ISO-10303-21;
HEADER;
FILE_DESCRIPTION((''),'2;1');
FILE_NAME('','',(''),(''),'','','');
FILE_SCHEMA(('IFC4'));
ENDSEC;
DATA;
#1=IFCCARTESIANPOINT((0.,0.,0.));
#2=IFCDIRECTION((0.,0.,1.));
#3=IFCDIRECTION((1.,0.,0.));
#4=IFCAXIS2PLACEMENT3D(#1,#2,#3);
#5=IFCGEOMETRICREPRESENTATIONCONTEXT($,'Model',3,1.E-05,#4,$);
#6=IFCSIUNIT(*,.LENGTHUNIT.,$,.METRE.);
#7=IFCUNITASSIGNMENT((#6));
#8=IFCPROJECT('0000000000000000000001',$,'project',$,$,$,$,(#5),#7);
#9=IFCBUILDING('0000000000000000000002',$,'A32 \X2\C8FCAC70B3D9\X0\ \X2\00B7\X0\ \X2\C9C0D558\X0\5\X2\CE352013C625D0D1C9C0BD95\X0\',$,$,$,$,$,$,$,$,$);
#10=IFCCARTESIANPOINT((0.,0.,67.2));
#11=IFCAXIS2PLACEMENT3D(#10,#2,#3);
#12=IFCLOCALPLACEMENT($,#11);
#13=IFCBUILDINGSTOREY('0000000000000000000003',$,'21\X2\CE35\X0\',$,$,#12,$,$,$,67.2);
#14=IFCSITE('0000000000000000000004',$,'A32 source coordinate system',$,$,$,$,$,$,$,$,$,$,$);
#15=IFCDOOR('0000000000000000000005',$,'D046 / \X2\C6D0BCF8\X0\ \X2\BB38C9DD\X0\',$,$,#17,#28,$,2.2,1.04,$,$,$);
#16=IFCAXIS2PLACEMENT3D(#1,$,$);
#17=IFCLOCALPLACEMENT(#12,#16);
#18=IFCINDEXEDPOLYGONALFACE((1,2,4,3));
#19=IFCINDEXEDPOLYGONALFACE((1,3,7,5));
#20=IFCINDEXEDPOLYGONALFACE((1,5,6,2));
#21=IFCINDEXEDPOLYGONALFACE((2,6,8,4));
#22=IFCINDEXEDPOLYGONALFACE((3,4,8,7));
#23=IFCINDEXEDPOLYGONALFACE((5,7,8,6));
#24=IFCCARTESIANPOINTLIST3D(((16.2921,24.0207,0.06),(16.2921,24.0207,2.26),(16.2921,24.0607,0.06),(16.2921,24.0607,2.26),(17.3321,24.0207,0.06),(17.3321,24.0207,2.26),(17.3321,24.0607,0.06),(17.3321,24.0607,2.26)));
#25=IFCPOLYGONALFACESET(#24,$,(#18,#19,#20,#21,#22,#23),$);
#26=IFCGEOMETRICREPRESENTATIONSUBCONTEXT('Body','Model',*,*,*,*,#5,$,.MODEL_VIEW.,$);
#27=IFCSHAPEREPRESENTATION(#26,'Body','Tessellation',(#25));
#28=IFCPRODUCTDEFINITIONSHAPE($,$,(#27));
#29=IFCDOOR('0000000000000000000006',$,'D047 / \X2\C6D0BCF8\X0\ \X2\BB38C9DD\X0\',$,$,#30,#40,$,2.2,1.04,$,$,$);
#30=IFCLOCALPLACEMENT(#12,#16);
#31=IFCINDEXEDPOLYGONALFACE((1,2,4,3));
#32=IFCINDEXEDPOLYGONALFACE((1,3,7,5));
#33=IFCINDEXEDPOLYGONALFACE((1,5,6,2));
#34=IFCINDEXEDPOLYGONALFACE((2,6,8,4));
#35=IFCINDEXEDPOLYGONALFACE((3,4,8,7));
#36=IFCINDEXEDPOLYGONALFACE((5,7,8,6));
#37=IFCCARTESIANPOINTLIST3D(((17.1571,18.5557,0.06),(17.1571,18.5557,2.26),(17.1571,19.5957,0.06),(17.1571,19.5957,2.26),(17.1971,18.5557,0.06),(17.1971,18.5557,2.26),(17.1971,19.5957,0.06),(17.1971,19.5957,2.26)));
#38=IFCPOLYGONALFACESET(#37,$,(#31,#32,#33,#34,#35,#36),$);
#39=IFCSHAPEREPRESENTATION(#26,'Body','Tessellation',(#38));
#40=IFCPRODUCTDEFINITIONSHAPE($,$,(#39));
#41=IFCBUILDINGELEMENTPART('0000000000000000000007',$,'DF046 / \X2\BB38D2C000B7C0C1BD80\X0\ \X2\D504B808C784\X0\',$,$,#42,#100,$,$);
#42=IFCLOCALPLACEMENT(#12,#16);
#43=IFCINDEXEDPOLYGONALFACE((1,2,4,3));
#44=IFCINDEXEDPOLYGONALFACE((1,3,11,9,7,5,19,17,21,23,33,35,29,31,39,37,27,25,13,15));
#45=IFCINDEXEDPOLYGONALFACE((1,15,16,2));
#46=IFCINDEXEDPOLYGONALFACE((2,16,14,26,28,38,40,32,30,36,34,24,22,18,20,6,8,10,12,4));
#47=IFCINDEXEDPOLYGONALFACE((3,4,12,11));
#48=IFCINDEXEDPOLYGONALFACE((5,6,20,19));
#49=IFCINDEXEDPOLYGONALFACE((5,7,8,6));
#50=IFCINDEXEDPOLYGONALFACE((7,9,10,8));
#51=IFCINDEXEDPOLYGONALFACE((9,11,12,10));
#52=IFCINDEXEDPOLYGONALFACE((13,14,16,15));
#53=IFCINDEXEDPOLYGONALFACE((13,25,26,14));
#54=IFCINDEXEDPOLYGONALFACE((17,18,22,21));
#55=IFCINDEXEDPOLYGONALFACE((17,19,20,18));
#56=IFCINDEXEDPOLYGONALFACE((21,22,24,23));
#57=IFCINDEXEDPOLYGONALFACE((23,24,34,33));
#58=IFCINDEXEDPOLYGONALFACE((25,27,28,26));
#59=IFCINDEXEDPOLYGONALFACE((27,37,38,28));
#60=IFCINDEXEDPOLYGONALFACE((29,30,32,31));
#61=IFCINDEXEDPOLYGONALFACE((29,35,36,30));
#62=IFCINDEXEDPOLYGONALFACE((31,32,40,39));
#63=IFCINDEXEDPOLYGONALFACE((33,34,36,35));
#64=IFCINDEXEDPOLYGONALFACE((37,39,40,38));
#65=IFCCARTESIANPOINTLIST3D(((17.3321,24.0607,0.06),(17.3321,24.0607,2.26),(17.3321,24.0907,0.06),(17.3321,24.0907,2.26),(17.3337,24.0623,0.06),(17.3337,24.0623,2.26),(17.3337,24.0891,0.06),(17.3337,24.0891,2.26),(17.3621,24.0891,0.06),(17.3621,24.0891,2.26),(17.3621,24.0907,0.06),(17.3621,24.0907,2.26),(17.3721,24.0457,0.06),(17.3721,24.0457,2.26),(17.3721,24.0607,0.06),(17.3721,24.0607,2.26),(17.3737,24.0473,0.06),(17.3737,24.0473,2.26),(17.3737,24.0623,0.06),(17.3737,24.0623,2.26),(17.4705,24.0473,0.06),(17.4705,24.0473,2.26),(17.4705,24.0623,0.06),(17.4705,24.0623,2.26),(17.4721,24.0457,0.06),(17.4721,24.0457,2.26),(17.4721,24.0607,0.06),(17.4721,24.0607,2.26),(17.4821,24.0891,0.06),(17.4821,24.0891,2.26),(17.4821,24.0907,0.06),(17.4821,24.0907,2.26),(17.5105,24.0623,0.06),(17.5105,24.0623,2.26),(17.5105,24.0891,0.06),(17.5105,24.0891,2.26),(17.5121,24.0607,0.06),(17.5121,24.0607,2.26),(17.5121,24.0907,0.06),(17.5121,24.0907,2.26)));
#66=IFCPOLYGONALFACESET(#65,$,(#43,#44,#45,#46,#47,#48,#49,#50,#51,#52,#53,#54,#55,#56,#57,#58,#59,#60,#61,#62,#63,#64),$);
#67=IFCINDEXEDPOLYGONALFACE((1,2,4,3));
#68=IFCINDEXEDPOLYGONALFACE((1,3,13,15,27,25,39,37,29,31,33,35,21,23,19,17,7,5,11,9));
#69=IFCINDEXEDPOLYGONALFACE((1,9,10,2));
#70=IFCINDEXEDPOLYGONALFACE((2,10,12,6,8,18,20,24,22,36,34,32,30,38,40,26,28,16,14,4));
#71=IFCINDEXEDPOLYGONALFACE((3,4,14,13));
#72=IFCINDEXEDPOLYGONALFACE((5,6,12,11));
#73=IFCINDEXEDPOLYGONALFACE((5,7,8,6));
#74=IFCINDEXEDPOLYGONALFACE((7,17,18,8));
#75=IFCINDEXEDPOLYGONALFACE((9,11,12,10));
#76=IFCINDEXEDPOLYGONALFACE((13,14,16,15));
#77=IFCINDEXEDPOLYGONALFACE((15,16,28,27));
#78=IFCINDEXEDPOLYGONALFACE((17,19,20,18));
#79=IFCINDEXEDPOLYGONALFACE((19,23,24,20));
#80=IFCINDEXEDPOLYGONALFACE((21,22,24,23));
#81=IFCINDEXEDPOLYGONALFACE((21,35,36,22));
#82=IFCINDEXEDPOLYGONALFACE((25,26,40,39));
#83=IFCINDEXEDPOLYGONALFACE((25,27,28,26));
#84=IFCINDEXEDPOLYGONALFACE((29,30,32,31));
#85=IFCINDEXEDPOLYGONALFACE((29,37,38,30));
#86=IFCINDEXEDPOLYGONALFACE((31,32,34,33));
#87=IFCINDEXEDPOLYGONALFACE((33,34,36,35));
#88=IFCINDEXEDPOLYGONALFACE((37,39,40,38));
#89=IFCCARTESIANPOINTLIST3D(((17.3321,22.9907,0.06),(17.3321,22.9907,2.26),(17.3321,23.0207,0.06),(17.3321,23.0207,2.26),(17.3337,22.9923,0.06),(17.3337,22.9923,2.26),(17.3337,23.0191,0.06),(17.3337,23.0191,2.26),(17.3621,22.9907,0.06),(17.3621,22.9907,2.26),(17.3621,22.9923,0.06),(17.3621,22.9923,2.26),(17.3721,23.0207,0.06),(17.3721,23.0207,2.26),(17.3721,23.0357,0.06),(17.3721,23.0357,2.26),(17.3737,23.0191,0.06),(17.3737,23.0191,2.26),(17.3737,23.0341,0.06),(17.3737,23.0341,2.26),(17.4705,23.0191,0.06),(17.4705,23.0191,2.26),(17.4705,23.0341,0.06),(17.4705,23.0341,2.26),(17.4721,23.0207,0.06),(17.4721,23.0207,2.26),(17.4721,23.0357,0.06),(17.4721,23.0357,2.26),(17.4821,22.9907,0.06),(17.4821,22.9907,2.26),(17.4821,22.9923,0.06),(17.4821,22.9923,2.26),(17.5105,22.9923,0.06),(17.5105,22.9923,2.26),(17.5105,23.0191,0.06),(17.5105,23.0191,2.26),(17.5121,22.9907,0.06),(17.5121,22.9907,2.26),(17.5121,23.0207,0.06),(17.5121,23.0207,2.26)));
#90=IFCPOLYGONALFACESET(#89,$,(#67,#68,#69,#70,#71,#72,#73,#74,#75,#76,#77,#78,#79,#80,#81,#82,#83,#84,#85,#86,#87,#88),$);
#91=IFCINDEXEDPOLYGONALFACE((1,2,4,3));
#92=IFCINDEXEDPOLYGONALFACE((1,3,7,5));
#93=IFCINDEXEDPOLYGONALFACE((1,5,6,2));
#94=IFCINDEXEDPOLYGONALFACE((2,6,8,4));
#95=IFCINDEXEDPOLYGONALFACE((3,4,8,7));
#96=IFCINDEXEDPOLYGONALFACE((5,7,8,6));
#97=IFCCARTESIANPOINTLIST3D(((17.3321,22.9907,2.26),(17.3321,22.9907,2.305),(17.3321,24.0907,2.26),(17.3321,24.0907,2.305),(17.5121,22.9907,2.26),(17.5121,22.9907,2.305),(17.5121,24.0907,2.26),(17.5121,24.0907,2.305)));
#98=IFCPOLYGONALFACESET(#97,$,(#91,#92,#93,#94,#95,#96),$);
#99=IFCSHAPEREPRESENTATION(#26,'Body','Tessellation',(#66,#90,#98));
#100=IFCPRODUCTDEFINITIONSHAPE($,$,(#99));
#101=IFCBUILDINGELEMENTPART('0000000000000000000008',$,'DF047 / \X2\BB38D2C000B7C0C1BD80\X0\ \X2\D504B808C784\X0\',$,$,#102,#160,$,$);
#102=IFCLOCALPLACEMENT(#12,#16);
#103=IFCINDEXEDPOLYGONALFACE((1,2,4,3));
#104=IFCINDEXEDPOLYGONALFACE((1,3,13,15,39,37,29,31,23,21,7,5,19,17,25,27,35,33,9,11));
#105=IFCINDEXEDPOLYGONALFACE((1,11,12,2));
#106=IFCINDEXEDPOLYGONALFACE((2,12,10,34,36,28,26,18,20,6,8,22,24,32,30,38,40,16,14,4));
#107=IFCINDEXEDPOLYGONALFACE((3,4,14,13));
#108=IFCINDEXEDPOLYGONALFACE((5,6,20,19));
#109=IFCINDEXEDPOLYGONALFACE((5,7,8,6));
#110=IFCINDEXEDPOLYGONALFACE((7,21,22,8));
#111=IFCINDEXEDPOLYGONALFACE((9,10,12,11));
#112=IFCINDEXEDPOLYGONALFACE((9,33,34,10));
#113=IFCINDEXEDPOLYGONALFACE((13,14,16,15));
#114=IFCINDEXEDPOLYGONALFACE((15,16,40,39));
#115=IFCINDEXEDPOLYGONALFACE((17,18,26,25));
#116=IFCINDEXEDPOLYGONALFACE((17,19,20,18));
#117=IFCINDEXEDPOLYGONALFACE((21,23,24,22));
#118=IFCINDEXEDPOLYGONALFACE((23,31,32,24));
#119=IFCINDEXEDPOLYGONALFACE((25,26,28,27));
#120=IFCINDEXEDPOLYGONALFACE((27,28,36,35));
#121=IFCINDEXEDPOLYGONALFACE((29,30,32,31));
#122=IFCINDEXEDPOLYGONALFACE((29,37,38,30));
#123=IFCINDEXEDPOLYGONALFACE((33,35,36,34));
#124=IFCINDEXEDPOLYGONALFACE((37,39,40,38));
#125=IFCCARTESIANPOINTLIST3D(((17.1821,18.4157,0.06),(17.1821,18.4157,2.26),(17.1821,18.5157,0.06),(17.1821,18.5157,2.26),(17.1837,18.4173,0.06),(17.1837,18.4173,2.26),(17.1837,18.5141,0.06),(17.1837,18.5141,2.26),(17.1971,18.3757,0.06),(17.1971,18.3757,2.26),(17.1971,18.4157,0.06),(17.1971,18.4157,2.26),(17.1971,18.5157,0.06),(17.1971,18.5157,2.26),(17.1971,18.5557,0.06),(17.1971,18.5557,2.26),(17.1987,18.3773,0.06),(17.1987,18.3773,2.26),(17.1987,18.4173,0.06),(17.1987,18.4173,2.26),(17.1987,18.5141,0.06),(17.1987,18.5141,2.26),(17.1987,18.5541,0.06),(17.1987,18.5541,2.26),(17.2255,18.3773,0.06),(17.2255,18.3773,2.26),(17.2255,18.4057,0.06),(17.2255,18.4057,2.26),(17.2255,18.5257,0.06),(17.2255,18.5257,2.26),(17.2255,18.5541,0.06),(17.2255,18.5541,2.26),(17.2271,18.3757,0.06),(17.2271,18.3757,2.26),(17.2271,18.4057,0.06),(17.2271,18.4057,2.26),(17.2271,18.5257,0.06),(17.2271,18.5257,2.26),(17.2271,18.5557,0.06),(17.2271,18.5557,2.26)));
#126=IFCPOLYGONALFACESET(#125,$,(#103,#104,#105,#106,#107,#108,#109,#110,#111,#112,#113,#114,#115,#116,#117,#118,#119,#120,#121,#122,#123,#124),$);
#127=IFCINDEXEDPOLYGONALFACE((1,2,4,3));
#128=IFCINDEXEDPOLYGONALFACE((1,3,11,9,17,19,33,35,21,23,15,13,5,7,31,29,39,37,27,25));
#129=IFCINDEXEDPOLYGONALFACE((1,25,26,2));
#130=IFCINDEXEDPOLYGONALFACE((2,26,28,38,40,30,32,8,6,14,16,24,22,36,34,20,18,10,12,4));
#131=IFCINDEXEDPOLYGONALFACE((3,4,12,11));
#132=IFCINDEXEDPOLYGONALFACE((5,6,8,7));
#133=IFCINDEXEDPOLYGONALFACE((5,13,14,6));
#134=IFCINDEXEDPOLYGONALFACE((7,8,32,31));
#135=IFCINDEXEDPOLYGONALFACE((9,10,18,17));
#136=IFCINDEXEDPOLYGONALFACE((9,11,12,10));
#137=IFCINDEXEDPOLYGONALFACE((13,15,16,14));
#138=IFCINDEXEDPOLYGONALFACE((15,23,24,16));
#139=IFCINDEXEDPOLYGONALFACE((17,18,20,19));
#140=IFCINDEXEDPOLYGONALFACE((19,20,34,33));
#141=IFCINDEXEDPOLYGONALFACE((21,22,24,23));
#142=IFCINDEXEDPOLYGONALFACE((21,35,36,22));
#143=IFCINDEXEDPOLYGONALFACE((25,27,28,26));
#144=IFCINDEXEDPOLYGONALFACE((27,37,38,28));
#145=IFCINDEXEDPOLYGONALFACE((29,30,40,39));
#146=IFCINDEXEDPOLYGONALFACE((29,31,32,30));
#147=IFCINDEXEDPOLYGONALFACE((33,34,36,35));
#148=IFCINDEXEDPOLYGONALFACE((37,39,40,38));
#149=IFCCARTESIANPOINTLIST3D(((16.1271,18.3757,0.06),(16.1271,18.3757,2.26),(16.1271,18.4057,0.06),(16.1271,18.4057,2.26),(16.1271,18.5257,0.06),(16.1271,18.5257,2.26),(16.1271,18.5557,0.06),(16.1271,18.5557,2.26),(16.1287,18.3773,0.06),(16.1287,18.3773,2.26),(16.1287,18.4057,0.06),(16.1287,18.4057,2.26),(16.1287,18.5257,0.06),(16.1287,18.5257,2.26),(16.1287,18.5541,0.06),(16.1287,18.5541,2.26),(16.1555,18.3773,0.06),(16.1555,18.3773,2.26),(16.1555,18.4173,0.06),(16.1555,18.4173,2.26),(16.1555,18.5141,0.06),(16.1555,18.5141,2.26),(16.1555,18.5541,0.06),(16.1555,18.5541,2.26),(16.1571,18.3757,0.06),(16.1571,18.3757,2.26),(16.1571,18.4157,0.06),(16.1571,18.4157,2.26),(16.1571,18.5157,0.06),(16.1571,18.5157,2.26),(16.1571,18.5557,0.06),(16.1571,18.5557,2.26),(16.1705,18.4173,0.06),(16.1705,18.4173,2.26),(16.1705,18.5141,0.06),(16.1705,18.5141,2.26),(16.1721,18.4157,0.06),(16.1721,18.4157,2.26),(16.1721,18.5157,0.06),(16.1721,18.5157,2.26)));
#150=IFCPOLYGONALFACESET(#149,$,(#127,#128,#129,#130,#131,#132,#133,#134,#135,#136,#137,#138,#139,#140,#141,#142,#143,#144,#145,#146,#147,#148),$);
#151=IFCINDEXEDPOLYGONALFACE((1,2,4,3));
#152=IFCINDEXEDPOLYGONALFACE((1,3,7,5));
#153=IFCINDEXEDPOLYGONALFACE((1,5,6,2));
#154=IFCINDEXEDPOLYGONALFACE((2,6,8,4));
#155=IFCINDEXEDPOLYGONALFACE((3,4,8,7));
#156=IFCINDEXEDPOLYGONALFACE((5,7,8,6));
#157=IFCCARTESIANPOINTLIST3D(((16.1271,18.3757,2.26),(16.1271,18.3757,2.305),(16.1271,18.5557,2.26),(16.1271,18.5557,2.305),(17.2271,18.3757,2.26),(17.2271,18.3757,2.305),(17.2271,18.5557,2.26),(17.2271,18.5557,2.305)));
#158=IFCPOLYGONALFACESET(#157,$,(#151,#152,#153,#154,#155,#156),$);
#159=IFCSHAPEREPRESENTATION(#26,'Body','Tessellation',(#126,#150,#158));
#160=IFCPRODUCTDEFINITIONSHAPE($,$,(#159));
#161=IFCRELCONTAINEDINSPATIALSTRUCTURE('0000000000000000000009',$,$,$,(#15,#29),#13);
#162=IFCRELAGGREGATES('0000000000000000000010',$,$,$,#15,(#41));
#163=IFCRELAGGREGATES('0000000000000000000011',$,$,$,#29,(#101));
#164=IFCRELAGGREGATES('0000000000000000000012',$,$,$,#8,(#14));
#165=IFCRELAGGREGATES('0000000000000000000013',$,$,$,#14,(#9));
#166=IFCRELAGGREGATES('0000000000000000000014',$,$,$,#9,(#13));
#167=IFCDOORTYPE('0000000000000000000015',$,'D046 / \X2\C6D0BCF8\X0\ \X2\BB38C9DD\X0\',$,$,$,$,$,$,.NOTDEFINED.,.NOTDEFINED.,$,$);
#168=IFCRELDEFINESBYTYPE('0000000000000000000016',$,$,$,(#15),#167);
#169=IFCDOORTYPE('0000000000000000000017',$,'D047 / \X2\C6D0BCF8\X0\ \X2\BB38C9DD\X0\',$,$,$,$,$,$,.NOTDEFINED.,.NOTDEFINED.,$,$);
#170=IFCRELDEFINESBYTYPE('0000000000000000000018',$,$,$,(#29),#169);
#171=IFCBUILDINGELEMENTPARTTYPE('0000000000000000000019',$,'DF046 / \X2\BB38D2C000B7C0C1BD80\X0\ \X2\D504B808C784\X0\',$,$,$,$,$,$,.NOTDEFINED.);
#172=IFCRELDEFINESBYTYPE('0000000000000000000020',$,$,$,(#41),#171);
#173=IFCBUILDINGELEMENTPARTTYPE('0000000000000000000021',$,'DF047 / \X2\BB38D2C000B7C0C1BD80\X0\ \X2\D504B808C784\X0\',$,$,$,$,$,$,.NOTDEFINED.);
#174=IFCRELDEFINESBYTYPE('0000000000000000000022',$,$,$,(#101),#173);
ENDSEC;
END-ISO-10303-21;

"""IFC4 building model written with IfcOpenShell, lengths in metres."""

from ifc_helpers import new_model, si_unit, frame, origin, origin_with_axes, place, context, subcontext, project, spatial, polyline, outline, extrude, source, transform, mapped, type_object, type_shapes, element, aggregate, save


model = new_model("IFC4")

# Units and contexts
model_context = context("Model", 3, precision=1e-05, world=origin_with_axes())
body_context = subcontext(model_context, "Body", "Model", "MODEL_VIEW")
ifc_project = project(units=[si_unit("LENGTHUNIT", "METRE")], contexts=[model_context])

# Site, building, storey
storey_placement = place(None, frame((0.0, 0.0, 67.2), z_axis=(0.0, 0.0, 1.0), x_axis=(1.0, 0.0, 0.0)))
site = spatial("IfcSite", under=ifc_project, Name="A32 source coordinate system")
building = spatial("IfcBuilding", under=site, Name="A32 주거동 · 지하5층–옥탑지붕")
storey = spatial("IfcBuildingStorey", under=building, at=storey_placement, Name="21층", Elevation=67.2)

# Doors
door_type_1 = type_object("IfcDoorType", Name="D046 / 원본 문짝", OperationType="NOTDEFINED", PredefinedType="NOTDEFINED")
shared_shape_1 = source(origin(), body_context, "Body", "SweptSolid", [
    extrude(outline(polyline([(17.3321, 24.0607), (17.3321, 24.0207), (16.2921, 24.0207), (16.2921, 24.0607), (17.3321, 24.0607)])), frame((0.0, 0.0, 0.06)), (0.0, 0.0, 1.0), 2.2),
])
type_shapes(door_type_1, [shared_shape_1])
door_1_placement = place(storey_placement, origin_with_axes())
door_1 = element("IfcDoor", 1, at=door_1_placement, inside=storey, type_object=door_type_1, Name="D046 / 원본 문짝", OverallHeight=2.2, OverallWidth=1.04, context=body_context, shape_type="MappedRepresentation", body=[
    mapped(shared_shape_1, transform((0.0, 0.0, 0.0), scale=1.0)),
])
door_type_2 = type_object("IfcDoorType", Name="D047 / 원본 문짝", OperationType="NOTDEFINED", PredefinedType="NOTDEFINED")
shared_shape_2 = source(origin(), body_context, "Body", "SweptSolid", [
    extrude(outline(polyline([(17.1971, 18.5557), (17.1571, 18.5557), (17.1571, 19.5957), (17.1971, 19.5957), (17.1971, 18.5557)])), frame((0.0, 0.0, 0.06)), (0.0, 0.0, 1.0), 2.2),
])
type_shapes(door_type_2, [shared_shape_2])
door_2_placement = place(storey_placement, origin_with_axes())
door_2 = element("IfcDoor", 2, at=door_2_placement, inside=storey, type_object=door_type_2, Name="D047 / 원본 문짝", OverallHeight=2.2, OverallWidth=1.04, context=body_context, shape_type="MappedRepresentation", body=[
    mapped(shared_shape_2, transform((0.0, 0.0, 0.0), scale=1.0)),
])

# Building element parts
building_element_part_type_1 = type_object("IfcBuildingElementPartType", Name="DF046 / 문틀·상부 프레임", PredefinedType="NOTDEFINED")
shared_shape_3 = source(origin(), body_context, "Body", "SweptSolid", [
    extrude(outline(polyline([(17.3337, 24.0891), (17.3337, 24.0623), (17.3737, 24.0623), (17.3737, 24.0473), (17.4705, 24.0473), (17.4705, 24.0623), (17.5105, 24.0623), (17.5105, 24.0891), (17.4821, 24.0891), (17.4821, 24.0907), (17.5121, 24.0907), (17.5121, 24.0607), (17.4721, 24.0607), (17.4721, 24.0457), (17.3721, 24.0457), (17.3721, 24.0607), (17.3321, 24.0607), (17.3321, 24.0907), (17.3621, 24.0907), (17.3621, 24.0891), (17.3337, 24.0891)])), frame((0.0, 0.0, 0.06)), (0.0, 0.0, 1.0), 2.2),
    extrude(outline(polyline([(17.3621, 22.9907), (17.3321, 22.9907), (17.3321, 23.0207), (17.3721, 23.0207), (17.3721, 23.0357), (17.4721, 23.0357), (17.4721, 23.0207), (17.5121, 23.0207), (17.5121, 22.9907), (17.4821, 22.9907), (17.4821, 22.9923), (17.5105, 22.9923), (17.5105, 23.0191), (17.4705, 23.0191), (17.4705, 23.0341), (17.3737, 23.0341), (17.3737, 23.0191), (17.3337, 23.0191), (17.3337, 22.9923), (17.3621, 22.9923), (17.3621, 22.9907)])), frame((0.0, 0.0, 0.06)), (0.0, 0.0, 1.0), 2.2),
    extrude(outline(polyline([(17.3321, 22.9907), (17.3321, 24.0907), (17.5121, 24.0907), (17.5121, 22.9907), (17.3321, 22.9907)])), frame((0.0, 0.0, 2.26)), (0.0, 0.0, 1.0), 0.045),
])
type_shapes(building_element_part_type_1, [shared_shape_3])
building_element_part_1_placement = place(door_1_placement, origin_with_axes())
building_element_part_1 = element("IfcBuildingElementPart", 3, at=building_element_part_1_placement, type_object=building_element_part_type_1, Name="DF046 / 문틀·상부 프레임", context=body_context, shape_type="MappedRepresentation", body=[
    mapped(shared_shape_3, transform((0.0, 0.0, 0.0), scale=1.0)),
])
aggregate(door_1, [building_element_part_1])
building_element_part_type_2 = type_object("IfcBuildingElementPartType", Name="DF047 / 문틀·상부 프레임", PredefinedType="NOTDEFINED")
shared_shape_4 = source(origin(), body_context, "Body", "SweptSolid", [
    extrude(outline(polyline([(17.2255, 18.5541), (17.1987, 18.5541), (17.1987, 18.5141), (17.1837, 18.5141), (17.1837, 18.4173), (17.1987, 18.4173), (17.1987, 18.3773), (17.2255, 18.3773), (17.2255, 18.4057), (17.2271, 18.4057), (17.2271, 18.3757), (17.1971, 18.3757), (17.1971, 18.4157), (17.1821, 18.4157), (17.1821, 18.5157), (17.1971, 18.5157), (17.1971, 18.5557), (17.2271, 18.5557), (17.2271, 18.5257), (17.2255, 18.5257), (17.2255, 18.5541)])), frame((0.0, 0.0, 0.06)), (0.0, 0.0, 1.0), 2.2),
    extrude(outline(polyline([(16.1271, 18.5257), (16.1271, 18.5557), (16.1571, 18.5557), (16.1571, 18.5157), (16.1721, 18.5157), (16.1721, 18.4157), (16.1571, 18.4157), (16.1571, 18.3757), (16.1271, 18.3757), (16.1271, 18.4057), (16.1287, 18.4057), (16.1287, 18.3773), (16.1555, 18.3773), (16.1555, 18.4173), (16.1705, 18.4173), (16.1705, 18.5141), (16.1555, 18.5141), (16.1555, 18.5541), (16.1287, 18.5541), (16.1287, 18.5257), (16.1271, 18.5257)])), frame((0.0, 0.0, 0.06)), (0.0, 0.0, 1.0), 2.2),
    extrude(outline(polyline([(16.1271, 18.3757), (16.1271, 18.5557), (17.2271, 18.5557), (17.2271, 18.3757), (16.1271, 18.3757)])), frame((0.0, 0.0, 2.26)), (0.0, 0.0, 1.0), 0.045),
])
type_shapes(building_element_part_type_2, [shared_shape_4])
building_element_part_2_placement = place(door_2_placement, origin_with_axes())
building_element_part_2 = element("IfcBuildingElementPart", 4, at=building_element_part_2_placement, type_object=building_element_part_type_2, Name="DF047 / 문틀·상부 프레임", context=body_context, shape_type="MappedRepresentation", body=[
    mapped(shared_shape_4, transform((0.0, 0.0, 0.0), scale=1.0)),
])
aggregate(door_2, [building_element_part_2])

save(model, "model.ifc")
